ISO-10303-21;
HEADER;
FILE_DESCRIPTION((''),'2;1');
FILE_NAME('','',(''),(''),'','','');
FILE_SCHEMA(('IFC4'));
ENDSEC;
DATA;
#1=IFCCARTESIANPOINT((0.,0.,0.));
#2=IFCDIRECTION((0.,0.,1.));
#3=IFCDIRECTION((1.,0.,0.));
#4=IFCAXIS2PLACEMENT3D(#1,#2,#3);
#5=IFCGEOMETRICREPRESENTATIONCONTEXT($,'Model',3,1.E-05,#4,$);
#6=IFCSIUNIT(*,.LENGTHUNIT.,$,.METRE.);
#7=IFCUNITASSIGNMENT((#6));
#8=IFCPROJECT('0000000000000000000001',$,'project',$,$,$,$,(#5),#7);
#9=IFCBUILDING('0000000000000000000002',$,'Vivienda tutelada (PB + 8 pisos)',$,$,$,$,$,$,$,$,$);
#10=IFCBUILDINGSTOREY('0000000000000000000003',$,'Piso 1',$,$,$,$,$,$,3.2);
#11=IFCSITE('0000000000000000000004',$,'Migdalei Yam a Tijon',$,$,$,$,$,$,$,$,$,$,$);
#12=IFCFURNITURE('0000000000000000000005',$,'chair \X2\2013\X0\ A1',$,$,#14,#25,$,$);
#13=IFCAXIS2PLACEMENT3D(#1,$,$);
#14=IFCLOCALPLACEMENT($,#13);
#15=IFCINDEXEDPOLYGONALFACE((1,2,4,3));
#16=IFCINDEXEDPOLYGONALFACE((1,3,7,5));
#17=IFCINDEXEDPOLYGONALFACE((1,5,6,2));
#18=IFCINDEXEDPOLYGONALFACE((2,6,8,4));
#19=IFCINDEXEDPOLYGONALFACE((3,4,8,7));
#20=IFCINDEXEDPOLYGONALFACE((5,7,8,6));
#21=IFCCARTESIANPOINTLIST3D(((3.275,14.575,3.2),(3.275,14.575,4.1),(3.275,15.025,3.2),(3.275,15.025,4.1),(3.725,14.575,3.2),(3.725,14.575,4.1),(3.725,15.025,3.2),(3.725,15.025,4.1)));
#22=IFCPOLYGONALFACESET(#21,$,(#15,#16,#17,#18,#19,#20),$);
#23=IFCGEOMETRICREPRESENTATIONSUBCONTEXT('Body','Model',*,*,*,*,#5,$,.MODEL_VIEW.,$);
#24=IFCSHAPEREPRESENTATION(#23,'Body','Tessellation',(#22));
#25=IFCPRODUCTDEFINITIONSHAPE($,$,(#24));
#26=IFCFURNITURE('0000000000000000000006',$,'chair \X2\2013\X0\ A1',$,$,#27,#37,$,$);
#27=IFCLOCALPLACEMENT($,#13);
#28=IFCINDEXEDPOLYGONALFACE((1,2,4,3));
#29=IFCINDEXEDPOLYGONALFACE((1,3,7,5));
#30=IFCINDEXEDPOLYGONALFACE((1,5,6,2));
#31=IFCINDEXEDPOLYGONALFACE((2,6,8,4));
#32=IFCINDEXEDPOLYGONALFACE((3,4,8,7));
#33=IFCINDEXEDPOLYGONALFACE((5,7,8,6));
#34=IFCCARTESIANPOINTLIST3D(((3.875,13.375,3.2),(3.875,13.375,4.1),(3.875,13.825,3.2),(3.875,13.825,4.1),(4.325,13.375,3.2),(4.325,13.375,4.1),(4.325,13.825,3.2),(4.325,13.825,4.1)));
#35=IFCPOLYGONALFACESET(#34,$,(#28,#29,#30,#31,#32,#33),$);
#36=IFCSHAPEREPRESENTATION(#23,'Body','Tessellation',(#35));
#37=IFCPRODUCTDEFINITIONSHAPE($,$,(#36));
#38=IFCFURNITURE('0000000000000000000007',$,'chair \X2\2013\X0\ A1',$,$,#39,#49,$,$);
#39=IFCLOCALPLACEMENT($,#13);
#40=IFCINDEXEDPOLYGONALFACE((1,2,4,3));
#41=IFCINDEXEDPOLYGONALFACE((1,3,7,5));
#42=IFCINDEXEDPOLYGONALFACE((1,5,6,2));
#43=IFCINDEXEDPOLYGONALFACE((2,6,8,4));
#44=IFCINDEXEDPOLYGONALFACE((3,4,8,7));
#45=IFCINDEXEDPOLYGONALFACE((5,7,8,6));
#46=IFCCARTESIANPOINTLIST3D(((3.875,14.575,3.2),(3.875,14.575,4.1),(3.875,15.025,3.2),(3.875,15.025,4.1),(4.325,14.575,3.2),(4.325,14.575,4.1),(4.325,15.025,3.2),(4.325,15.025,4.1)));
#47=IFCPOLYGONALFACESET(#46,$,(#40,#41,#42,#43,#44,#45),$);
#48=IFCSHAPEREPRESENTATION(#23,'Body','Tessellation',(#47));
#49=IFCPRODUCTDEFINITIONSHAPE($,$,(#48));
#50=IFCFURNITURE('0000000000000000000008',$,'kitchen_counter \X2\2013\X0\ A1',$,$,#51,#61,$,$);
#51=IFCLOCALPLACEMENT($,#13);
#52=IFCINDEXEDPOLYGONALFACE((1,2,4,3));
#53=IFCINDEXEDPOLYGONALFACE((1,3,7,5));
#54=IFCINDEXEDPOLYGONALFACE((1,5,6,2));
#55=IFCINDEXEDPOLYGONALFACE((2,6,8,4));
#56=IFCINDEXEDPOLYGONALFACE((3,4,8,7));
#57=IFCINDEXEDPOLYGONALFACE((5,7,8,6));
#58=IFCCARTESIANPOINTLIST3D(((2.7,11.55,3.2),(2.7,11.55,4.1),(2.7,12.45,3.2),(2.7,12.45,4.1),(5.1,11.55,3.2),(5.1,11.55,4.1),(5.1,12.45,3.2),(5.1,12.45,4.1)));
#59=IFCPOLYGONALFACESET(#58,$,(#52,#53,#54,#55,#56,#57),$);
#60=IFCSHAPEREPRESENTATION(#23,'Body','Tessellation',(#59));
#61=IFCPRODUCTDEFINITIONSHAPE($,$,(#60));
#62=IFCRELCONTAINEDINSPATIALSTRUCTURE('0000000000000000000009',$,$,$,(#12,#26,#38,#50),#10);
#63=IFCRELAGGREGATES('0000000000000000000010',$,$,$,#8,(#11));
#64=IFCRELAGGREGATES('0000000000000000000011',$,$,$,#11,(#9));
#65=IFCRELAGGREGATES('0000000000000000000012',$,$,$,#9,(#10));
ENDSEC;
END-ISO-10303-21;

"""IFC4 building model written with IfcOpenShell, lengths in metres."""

from ifc_helpers import new_model, si_unit, frame, origin_with_axes, context, subcontext, project, spatial, line, indexed_curve, outline, extrude, element, save


model = new_model("IFC4")

# Units and contexts
model_context = context("Model", 3, precision=1e-05, world=origin_with_axes())
body_context = subcontext(model_context, "Body", "Model", "MODEL_VIEW")
ifc_project = project(units=[si_unit("LENGTHUNIT", "METRE")], contexts=[model_context])

# Site, building, storey
site = spatial("IfcSite", under=ifc_project, Name="Migdalei Yam a Tijon")
building = spatial("IfcBuilding", under=site, Name="Vivienda tutelada (PB + 8 pisos)")
storey = spatial("IfcBuildingStorey", under=building, Name="Piso 1", Elevation=3.2)

# Furniture
element("IfcFurniture", 1, inside=storey, Name="chair – A1", context=body_context, shape_type="SweptSolid", body=[
    extrude(outline(indexed_curve([(0.0, 0.0), (0.45, 0.0), (0.45, 0.45), (0.0, 0.45)], segments=[line(1, 2, 3, 4, 1)])), frame((3.275, 14.575, 3.2), z_axis=(0.0, 0.0, 1.0), x_axis=(1.0, 0.0, 0.0)), (0.0, 0.0, 1.0), 0.9),
])
element("IfcFurniture", 2, inside=storey, Name="chair – A1", context=body_context, shape_type="SweptSolid", body=[
    extrude(outline(indexed_curve([(0.0, 0.0), (0.45, 0.0), (0.45, 0.45), (0.0, 0.45)], segments=[line(1, 2, 3, 4, 1)])), frame((3.875, 13.375, 3.2), z_axis=(0.0, 0.0, 1.0), x_axis=(1.0, 0.0, 0.0)), (0.0, 0.0, 1.0), 0.9),
])
element("IfcFurniture", 3, inside=storey, Name="chair – A1", context=body_context, shape_type="SweptSolid", body=[
    extrude(outline(indexed_curve([(0.0, 0.0), (0.45, 0.0), (0.45, 0.45), (0.0, 0.45)], segments=[line(1, 2, 3, 4, 1)])), frame((3.875, 14.575, 3.2), z_axis=(0.0, 0.0, 1.0), x_axis=(1.0, 0.0, 0.0)), (0.0, 0.0, 1.0), 0.9),
])
element("IfcFurniture", 4, inside=storey, Name="kitchen_counter – A1", context=body_context, shape_type="SweptSolid", body=[
    extrude(outline(indexed_curve([(0.0, 0.0), (2.4, 0.0), (2.4, 0.9), (0.0, 0.9)], segments=[line(1, 2, 3, 4, 1)])), frame((2.7, 11.55, 3.2), z_axis=(0.0, 0.0, 1.0), x_axis=(1.0, 0.0, 0.0)), (0.0, 0.0, 1.0), 0.9),
])

save(model, "model.ifc")
